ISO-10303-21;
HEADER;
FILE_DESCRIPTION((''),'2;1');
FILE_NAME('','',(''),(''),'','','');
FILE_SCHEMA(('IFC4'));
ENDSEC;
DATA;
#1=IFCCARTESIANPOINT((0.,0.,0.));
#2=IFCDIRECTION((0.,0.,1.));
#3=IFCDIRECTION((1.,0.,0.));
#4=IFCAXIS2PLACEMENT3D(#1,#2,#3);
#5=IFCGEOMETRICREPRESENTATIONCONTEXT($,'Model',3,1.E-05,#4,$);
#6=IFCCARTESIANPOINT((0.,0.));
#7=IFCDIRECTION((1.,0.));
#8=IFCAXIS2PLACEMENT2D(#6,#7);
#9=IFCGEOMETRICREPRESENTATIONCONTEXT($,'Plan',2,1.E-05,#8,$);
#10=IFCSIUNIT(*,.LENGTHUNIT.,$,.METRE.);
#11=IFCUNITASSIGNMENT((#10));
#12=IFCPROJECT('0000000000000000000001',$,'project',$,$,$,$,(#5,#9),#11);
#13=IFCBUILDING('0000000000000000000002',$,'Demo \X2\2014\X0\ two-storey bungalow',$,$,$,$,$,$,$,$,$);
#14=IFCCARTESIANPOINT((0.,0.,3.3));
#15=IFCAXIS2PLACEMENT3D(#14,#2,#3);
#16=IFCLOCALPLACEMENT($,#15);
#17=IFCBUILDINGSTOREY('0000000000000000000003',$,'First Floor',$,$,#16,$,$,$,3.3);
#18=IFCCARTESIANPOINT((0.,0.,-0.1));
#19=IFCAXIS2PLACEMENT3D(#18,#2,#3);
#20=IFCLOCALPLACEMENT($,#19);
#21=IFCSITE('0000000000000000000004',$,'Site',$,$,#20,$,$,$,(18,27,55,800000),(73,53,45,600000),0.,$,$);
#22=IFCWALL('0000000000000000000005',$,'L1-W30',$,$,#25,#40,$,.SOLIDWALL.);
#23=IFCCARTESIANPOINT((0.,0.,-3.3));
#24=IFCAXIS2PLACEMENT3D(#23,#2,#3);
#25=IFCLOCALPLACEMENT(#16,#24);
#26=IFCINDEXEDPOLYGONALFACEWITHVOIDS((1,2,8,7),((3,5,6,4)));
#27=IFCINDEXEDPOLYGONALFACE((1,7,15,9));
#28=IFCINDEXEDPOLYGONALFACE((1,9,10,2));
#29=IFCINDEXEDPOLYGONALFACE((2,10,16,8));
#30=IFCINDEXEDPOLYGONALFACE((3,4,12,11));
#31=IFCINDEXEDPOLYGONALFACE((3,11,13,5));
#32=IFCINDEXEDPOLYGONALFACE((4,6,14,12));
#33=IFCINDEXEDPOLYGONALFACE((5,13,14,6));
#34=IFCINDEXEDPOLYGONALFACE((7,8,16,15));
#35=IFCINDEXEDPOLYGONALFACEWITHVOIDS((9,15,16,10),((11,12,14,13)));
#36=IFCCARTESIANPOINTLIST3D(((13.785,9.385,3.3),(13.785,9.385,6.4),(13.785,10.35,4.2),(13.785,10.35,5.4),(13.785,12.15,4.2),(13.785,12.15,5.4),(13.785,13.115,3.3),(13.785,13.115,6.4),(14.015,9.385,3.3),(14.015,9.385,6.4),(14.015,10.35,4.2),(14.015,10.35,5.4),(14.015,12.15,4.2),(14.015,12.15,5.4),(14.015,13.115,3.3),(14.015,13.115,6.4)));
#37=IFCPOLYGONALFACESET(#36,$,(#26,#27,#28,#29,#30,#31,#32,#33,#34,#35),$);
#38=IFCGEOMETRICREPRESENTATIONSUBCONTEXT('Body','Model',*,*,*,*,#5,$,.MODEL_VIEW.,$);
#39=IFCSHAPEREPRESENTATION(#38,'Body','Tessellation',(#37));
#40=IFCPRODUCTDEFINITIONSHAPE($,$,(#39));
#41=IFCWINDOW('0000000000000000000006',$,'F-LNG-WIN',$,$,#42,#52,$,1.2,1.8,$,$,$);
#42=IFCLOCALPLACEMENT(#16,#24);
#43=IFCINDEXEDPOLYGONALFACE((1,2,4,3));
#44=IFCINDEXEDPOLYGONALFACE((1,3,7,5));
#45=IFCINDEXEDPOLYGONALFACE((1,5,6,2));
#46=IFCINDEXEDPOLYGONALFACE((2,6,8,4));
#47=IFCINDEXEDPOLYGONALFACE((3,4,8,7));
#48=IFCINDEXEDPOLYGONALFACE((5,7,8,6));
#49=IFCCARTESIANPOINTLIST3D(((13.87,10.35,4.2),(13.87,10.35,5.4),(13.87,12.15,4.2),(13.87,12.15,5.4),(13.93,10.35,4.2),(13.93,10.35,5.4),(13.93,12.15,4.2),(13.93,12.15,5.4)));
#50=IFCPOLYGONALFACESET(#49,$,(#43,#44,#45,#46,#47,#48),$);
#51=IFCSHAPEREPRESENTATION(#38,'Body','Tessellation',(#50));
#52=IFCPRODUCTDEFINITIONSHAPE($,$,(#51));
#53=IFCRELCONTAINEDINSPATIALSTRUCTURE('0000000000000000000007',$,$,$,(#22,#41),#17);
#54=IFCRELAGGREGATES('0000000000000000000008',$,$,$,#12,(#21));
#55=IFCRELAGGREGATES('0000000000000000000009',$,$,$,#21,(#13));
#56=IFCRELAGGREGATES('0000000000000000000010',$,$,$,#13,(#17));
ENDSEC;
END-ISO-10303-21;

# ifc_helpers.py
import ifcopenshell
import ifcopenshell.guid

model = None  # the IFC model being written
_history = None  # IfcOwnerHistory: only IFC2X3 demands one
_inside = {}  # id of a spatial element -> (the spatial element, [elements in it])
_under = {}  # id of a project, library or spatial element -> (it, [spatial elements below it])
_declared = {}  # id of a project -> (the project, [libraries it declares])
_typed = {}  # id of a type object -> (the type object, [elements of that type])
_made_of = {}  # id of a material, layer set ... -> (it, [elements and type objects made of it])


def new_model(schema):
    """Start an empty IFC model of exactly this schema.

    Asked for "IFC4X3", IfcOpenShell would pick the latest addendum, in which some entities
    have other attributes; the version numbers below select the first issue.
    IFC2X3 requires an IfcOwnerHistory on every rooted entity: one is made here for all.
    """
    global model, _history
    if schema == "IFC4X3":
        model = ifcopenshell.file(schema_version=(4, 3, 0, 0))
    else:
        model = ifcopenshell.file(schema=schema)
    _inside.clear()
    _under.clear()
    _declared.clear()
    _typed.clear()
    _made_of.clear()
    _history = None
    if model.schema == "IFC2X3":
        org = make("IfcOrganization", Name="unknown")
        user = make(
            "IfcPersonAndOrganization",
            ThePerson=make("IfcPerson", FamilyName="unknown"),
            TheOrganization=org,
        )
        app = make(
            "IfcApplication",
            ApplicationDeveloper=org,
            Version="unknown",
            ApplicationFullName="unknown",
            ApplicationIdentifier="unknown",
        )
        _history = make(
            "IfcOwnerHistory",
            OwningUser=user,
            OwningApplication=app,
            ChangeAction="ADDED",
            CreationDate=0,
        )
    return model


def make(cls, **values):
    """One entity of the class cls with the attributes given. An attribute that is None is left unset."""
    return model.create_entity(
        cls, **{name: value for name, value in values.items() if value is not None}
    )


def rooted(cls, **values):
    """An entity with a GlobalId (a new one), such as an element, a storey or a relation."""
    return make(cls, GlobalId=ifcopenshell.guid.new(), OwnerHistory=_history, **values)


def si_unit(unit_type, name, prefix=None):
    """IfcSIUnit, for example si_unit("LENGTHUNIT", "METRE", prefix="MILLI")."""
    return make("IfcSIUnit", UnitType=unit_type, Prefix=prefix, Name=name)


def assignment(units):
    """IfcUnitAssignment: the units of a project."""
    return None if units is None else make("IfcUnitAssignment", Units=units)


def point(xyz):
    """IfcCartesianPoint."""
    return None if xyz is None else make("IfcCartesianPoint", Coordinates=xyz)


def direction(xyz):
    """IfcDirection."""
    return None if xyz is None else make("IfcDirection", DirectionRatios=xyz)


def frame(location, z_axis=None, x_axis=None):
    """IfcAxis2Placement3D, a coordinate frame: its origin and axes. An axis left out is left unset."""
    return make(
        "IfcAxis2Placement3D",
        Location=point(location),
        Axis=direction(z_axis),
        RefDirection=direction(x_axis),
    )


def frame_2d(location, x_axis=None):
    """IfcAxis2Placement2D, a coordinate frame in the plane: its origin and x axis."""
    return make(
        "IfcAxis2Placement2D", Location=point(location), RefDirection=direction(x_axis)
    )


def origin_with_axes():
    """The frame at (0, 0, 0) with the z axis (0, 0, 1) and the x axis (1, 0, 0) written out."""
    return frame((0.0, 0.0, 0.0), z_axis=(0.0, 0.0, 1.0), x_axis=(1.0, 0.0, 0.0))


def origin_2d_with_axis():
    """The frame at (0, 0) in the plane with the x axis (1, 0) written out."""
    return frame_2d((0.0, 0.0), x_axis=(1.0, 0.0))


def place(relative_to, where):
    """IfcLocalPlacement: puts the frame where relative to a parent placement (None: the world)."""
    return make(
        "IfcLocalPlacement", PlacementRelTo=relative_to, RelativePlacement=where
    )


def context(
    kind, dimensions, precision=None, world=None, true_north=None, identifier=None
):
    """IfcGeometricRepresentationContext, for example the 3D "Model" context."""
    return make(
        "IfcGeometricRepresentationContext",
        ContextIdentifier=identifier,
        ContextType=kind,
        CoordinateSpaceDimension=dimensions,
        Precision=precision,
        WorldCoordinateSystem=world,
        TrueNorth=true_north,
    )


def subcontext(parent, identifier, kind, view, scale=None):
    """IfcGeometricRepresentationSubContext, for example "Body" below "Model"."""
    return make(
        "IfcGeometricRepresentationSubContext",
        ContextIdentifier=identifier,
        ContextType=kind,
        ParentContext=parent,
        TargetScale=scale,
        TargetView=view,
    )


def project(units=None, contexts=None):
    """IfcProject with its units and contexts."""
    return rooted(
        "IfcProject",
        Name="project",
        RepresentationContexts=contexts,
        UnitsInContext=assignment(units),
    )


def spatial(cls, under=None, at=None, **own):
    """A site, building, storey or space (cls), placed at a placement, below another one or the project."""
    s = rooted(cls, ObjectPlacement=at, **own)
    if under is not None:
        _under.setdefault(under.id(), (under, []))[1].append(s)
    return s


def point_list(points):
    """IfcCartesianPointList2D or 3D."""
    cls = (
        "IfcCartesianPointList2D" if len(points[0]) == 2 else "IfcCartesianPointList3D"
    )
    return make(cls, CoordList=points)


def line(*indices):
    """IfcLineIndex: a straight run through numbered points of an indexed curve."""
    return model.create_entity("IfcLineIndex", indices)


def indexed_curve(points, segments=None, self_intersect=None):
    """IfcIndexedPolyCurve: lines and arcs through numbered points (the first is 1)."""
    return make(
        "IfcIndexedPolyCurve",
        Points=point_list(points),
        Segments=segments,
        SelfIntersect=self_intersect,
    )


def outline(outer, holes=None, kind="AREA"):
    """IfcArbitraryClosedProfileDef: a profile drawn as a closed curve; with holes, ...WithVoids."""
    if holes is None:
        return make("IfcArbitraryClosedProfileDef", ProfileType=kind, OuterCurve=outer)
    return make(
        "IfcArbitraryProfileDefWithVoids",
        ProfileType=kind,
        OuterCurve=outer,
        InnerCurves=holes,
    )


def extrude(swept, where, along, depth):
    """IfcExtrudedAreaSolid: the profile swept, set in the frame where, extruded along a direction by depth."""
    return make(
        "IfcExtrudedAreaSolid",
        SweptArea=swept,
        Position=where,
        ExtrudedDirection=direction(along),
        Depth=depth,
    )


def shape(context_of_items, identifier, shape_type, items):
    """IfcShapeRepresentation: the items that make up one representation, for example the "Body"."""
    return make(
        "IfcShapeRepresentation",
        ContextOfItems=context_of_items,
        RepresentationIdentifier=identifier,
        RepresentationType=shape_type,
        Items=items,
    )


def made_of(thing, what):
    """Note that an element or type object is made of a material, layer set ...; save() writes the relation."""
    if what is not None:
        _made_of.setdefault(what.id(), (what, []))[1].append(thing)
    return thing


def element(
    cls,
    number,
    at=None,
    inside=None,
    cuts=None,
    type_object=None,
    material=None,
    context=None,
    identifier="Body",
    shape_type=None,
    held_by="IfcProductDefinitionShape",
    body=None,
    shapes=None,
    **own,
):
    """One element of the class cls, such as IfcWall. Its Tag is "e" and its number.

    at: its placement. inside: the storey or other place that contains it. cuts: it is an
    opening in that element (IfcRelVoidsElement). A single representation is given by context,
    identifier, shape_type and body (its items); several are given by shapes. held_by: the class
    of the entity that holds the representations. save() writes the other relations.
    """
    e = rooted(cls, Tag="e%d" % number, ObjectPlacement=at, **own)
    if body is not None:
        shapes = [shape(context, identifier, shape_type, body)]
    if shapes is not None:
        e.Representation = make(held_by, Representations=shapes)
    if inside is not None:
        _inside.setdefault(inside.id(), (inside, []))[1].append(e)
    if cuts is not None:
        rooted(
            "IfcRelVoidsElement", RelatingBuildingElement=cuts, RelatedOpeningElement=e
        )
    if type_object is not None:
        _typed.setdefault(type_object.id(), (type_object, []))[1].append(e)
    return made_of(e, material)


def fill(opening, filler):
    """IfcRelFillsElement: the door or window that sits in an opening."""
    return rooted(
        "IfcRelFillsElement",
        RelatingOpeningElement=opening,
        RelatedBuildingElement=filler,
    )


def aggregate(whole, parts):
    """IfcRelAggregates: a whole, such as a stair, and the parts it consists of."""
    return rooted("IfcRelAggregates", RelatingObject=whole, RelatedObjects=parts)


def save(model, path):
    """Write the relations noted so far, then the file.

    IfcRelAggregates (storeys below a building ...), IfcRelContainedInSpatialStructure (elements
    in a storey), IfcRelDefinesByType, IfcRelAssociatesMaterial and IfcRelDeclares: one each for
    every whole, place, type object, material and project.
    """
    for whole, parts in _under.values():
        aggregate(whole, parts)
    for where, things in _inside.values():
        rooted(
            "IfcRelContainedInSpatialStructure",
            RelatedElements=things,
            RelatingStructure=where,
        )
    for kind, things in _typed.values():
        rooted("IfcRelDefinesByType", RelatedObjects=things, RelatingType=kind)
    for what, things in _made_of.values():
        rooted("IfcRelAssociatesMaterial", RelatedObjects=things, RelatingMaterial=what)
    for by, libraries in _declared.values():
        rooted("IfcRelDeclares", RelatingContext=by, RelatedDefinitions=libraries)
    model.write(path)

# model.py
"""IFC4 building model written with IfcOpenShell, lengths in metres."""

from ifc_helpers import new_model, si_unit, frame, origin_with_axes, origin_2d_with_axis, place, context, subcontext, project, spatial, line, indexed_curve, outline, extrude, element, fill, save


model = new_model("IFC4")

# Units and contexts
model_context = context("Model", 3, precision=1e-05, world=origin_with_axes())
plan_context = context("Plan", 2, precision=1e-05, world=origin_2d_with_axis())
body_context = subcontext(model_context, "Body", "Model", "MODEL_VIEW")
ifc_project = project(units=[si_unit("LENGTHUNIT", "METRE")], contexts=[model_context, plan_context])

# Site, building, storey
site_placement = place(None, frame((0.0, 0.0, -0.1), z_axis=(0.0, 0.0, 1.0), x_axis=(1.0, 0.0, 0.0)))
site = spatial("IfcSite", under=ifc_project, at=site_placement, Name="Site", RefLatitude=(18, 27, 55, 800000), RefLongitude=(73, 53, 45, 600000), RefElevation=0.0)
building = spatial("IfcBuilding", under=site, Name="Demo — two-storey bungalow")
storey_placement = place(None, frame((0.0, 0.0, 3.3), z_axis=(0.0, 0.0, 1.0), x_axis=(1.0, 0.0, 0.0)))
storey = spatial("IfcBuildingStorey", under=building, at=storey_placement, Name="First Floor", Elevation=3.3)

# Wall, opening, window
wall_1_placement = place(storey_placement, frame((0.0, 0.0, -3.3), z_axis=(0.0, 0.0, 1.0), x_axis=(1.0, 0.0, 0.0)))
wall_1 = element("IfcWall", 1, at=wall_1_placement, inside=storey, Name="L1-W30", PredefinedType="SOLIDWALL", context=body_context, shape_type="SweptSolid", body=[
    extrude(outline(indexed_curve([(13.785, 9.385), (13.785, 13.115), (14.015, 13.115), (14.015, 9.385)], segments=[line(1, 2, 3, 4, 1)])), frame((0.0, 0.0, 3.3), z_axis=(0.0, 0.0, 1.0), x_axis=(1.0, 0.0, 0.0)), (0.0, 0.0, 1.0), 3.1),
])
opening_1_placement = place(wall_1_placement, origin_with_axes())
opening_1 = element("IfcOpeningElement", 2, at=opening_1_placement, cuts=wall_1, context=body_context, shape_type="SweptSolid", body=[
    extrude(outline(indexed_curve([(13.735, 10.35), (13.735, 12.15), (14.065, 12.15), (14.065, 10.35)], segments=[line(1, 2, 3, 4, 1)])), frame((0.0, 0.0, 4.2), z_axis=(0.0, 0.0, 1.0), x_axis=(1.0, 0.0, 0.0)), (0.0, 0.0, 1.0), 1.2),
])
window_1_placement = place(storey_placement, frame((0.0, 0.0, -3.3), z_axis=(0.0, 0.0, 1.0), x_axis=(1.0, 0.0, 0.0)))
window_1 = element("IfcWindow", 3, at=window_1_placement, inside=storey, Name="F-LNG-WIN", OverallHeight=1.2, OverallWidth=1.8, context=body_context, shape_type="SweptSolid", body=[
    extrude(outline(indexed_curve([(13.87, 10.35), (13.87, 12.15), (13.93, 12.15), (13.93, 10.35)], segments=[line(1, 2, 3, 4, 1)])), frame((0.0, 0.0, 4.2), z_axis=(0.0, 0.0, 1.0), x_axis=(1.0, 0.0, 0.0)), (0.0, 0.0, 1.0), 1.2),
])
fill(opening_1, window_1)

save(model, "model.ifc")
